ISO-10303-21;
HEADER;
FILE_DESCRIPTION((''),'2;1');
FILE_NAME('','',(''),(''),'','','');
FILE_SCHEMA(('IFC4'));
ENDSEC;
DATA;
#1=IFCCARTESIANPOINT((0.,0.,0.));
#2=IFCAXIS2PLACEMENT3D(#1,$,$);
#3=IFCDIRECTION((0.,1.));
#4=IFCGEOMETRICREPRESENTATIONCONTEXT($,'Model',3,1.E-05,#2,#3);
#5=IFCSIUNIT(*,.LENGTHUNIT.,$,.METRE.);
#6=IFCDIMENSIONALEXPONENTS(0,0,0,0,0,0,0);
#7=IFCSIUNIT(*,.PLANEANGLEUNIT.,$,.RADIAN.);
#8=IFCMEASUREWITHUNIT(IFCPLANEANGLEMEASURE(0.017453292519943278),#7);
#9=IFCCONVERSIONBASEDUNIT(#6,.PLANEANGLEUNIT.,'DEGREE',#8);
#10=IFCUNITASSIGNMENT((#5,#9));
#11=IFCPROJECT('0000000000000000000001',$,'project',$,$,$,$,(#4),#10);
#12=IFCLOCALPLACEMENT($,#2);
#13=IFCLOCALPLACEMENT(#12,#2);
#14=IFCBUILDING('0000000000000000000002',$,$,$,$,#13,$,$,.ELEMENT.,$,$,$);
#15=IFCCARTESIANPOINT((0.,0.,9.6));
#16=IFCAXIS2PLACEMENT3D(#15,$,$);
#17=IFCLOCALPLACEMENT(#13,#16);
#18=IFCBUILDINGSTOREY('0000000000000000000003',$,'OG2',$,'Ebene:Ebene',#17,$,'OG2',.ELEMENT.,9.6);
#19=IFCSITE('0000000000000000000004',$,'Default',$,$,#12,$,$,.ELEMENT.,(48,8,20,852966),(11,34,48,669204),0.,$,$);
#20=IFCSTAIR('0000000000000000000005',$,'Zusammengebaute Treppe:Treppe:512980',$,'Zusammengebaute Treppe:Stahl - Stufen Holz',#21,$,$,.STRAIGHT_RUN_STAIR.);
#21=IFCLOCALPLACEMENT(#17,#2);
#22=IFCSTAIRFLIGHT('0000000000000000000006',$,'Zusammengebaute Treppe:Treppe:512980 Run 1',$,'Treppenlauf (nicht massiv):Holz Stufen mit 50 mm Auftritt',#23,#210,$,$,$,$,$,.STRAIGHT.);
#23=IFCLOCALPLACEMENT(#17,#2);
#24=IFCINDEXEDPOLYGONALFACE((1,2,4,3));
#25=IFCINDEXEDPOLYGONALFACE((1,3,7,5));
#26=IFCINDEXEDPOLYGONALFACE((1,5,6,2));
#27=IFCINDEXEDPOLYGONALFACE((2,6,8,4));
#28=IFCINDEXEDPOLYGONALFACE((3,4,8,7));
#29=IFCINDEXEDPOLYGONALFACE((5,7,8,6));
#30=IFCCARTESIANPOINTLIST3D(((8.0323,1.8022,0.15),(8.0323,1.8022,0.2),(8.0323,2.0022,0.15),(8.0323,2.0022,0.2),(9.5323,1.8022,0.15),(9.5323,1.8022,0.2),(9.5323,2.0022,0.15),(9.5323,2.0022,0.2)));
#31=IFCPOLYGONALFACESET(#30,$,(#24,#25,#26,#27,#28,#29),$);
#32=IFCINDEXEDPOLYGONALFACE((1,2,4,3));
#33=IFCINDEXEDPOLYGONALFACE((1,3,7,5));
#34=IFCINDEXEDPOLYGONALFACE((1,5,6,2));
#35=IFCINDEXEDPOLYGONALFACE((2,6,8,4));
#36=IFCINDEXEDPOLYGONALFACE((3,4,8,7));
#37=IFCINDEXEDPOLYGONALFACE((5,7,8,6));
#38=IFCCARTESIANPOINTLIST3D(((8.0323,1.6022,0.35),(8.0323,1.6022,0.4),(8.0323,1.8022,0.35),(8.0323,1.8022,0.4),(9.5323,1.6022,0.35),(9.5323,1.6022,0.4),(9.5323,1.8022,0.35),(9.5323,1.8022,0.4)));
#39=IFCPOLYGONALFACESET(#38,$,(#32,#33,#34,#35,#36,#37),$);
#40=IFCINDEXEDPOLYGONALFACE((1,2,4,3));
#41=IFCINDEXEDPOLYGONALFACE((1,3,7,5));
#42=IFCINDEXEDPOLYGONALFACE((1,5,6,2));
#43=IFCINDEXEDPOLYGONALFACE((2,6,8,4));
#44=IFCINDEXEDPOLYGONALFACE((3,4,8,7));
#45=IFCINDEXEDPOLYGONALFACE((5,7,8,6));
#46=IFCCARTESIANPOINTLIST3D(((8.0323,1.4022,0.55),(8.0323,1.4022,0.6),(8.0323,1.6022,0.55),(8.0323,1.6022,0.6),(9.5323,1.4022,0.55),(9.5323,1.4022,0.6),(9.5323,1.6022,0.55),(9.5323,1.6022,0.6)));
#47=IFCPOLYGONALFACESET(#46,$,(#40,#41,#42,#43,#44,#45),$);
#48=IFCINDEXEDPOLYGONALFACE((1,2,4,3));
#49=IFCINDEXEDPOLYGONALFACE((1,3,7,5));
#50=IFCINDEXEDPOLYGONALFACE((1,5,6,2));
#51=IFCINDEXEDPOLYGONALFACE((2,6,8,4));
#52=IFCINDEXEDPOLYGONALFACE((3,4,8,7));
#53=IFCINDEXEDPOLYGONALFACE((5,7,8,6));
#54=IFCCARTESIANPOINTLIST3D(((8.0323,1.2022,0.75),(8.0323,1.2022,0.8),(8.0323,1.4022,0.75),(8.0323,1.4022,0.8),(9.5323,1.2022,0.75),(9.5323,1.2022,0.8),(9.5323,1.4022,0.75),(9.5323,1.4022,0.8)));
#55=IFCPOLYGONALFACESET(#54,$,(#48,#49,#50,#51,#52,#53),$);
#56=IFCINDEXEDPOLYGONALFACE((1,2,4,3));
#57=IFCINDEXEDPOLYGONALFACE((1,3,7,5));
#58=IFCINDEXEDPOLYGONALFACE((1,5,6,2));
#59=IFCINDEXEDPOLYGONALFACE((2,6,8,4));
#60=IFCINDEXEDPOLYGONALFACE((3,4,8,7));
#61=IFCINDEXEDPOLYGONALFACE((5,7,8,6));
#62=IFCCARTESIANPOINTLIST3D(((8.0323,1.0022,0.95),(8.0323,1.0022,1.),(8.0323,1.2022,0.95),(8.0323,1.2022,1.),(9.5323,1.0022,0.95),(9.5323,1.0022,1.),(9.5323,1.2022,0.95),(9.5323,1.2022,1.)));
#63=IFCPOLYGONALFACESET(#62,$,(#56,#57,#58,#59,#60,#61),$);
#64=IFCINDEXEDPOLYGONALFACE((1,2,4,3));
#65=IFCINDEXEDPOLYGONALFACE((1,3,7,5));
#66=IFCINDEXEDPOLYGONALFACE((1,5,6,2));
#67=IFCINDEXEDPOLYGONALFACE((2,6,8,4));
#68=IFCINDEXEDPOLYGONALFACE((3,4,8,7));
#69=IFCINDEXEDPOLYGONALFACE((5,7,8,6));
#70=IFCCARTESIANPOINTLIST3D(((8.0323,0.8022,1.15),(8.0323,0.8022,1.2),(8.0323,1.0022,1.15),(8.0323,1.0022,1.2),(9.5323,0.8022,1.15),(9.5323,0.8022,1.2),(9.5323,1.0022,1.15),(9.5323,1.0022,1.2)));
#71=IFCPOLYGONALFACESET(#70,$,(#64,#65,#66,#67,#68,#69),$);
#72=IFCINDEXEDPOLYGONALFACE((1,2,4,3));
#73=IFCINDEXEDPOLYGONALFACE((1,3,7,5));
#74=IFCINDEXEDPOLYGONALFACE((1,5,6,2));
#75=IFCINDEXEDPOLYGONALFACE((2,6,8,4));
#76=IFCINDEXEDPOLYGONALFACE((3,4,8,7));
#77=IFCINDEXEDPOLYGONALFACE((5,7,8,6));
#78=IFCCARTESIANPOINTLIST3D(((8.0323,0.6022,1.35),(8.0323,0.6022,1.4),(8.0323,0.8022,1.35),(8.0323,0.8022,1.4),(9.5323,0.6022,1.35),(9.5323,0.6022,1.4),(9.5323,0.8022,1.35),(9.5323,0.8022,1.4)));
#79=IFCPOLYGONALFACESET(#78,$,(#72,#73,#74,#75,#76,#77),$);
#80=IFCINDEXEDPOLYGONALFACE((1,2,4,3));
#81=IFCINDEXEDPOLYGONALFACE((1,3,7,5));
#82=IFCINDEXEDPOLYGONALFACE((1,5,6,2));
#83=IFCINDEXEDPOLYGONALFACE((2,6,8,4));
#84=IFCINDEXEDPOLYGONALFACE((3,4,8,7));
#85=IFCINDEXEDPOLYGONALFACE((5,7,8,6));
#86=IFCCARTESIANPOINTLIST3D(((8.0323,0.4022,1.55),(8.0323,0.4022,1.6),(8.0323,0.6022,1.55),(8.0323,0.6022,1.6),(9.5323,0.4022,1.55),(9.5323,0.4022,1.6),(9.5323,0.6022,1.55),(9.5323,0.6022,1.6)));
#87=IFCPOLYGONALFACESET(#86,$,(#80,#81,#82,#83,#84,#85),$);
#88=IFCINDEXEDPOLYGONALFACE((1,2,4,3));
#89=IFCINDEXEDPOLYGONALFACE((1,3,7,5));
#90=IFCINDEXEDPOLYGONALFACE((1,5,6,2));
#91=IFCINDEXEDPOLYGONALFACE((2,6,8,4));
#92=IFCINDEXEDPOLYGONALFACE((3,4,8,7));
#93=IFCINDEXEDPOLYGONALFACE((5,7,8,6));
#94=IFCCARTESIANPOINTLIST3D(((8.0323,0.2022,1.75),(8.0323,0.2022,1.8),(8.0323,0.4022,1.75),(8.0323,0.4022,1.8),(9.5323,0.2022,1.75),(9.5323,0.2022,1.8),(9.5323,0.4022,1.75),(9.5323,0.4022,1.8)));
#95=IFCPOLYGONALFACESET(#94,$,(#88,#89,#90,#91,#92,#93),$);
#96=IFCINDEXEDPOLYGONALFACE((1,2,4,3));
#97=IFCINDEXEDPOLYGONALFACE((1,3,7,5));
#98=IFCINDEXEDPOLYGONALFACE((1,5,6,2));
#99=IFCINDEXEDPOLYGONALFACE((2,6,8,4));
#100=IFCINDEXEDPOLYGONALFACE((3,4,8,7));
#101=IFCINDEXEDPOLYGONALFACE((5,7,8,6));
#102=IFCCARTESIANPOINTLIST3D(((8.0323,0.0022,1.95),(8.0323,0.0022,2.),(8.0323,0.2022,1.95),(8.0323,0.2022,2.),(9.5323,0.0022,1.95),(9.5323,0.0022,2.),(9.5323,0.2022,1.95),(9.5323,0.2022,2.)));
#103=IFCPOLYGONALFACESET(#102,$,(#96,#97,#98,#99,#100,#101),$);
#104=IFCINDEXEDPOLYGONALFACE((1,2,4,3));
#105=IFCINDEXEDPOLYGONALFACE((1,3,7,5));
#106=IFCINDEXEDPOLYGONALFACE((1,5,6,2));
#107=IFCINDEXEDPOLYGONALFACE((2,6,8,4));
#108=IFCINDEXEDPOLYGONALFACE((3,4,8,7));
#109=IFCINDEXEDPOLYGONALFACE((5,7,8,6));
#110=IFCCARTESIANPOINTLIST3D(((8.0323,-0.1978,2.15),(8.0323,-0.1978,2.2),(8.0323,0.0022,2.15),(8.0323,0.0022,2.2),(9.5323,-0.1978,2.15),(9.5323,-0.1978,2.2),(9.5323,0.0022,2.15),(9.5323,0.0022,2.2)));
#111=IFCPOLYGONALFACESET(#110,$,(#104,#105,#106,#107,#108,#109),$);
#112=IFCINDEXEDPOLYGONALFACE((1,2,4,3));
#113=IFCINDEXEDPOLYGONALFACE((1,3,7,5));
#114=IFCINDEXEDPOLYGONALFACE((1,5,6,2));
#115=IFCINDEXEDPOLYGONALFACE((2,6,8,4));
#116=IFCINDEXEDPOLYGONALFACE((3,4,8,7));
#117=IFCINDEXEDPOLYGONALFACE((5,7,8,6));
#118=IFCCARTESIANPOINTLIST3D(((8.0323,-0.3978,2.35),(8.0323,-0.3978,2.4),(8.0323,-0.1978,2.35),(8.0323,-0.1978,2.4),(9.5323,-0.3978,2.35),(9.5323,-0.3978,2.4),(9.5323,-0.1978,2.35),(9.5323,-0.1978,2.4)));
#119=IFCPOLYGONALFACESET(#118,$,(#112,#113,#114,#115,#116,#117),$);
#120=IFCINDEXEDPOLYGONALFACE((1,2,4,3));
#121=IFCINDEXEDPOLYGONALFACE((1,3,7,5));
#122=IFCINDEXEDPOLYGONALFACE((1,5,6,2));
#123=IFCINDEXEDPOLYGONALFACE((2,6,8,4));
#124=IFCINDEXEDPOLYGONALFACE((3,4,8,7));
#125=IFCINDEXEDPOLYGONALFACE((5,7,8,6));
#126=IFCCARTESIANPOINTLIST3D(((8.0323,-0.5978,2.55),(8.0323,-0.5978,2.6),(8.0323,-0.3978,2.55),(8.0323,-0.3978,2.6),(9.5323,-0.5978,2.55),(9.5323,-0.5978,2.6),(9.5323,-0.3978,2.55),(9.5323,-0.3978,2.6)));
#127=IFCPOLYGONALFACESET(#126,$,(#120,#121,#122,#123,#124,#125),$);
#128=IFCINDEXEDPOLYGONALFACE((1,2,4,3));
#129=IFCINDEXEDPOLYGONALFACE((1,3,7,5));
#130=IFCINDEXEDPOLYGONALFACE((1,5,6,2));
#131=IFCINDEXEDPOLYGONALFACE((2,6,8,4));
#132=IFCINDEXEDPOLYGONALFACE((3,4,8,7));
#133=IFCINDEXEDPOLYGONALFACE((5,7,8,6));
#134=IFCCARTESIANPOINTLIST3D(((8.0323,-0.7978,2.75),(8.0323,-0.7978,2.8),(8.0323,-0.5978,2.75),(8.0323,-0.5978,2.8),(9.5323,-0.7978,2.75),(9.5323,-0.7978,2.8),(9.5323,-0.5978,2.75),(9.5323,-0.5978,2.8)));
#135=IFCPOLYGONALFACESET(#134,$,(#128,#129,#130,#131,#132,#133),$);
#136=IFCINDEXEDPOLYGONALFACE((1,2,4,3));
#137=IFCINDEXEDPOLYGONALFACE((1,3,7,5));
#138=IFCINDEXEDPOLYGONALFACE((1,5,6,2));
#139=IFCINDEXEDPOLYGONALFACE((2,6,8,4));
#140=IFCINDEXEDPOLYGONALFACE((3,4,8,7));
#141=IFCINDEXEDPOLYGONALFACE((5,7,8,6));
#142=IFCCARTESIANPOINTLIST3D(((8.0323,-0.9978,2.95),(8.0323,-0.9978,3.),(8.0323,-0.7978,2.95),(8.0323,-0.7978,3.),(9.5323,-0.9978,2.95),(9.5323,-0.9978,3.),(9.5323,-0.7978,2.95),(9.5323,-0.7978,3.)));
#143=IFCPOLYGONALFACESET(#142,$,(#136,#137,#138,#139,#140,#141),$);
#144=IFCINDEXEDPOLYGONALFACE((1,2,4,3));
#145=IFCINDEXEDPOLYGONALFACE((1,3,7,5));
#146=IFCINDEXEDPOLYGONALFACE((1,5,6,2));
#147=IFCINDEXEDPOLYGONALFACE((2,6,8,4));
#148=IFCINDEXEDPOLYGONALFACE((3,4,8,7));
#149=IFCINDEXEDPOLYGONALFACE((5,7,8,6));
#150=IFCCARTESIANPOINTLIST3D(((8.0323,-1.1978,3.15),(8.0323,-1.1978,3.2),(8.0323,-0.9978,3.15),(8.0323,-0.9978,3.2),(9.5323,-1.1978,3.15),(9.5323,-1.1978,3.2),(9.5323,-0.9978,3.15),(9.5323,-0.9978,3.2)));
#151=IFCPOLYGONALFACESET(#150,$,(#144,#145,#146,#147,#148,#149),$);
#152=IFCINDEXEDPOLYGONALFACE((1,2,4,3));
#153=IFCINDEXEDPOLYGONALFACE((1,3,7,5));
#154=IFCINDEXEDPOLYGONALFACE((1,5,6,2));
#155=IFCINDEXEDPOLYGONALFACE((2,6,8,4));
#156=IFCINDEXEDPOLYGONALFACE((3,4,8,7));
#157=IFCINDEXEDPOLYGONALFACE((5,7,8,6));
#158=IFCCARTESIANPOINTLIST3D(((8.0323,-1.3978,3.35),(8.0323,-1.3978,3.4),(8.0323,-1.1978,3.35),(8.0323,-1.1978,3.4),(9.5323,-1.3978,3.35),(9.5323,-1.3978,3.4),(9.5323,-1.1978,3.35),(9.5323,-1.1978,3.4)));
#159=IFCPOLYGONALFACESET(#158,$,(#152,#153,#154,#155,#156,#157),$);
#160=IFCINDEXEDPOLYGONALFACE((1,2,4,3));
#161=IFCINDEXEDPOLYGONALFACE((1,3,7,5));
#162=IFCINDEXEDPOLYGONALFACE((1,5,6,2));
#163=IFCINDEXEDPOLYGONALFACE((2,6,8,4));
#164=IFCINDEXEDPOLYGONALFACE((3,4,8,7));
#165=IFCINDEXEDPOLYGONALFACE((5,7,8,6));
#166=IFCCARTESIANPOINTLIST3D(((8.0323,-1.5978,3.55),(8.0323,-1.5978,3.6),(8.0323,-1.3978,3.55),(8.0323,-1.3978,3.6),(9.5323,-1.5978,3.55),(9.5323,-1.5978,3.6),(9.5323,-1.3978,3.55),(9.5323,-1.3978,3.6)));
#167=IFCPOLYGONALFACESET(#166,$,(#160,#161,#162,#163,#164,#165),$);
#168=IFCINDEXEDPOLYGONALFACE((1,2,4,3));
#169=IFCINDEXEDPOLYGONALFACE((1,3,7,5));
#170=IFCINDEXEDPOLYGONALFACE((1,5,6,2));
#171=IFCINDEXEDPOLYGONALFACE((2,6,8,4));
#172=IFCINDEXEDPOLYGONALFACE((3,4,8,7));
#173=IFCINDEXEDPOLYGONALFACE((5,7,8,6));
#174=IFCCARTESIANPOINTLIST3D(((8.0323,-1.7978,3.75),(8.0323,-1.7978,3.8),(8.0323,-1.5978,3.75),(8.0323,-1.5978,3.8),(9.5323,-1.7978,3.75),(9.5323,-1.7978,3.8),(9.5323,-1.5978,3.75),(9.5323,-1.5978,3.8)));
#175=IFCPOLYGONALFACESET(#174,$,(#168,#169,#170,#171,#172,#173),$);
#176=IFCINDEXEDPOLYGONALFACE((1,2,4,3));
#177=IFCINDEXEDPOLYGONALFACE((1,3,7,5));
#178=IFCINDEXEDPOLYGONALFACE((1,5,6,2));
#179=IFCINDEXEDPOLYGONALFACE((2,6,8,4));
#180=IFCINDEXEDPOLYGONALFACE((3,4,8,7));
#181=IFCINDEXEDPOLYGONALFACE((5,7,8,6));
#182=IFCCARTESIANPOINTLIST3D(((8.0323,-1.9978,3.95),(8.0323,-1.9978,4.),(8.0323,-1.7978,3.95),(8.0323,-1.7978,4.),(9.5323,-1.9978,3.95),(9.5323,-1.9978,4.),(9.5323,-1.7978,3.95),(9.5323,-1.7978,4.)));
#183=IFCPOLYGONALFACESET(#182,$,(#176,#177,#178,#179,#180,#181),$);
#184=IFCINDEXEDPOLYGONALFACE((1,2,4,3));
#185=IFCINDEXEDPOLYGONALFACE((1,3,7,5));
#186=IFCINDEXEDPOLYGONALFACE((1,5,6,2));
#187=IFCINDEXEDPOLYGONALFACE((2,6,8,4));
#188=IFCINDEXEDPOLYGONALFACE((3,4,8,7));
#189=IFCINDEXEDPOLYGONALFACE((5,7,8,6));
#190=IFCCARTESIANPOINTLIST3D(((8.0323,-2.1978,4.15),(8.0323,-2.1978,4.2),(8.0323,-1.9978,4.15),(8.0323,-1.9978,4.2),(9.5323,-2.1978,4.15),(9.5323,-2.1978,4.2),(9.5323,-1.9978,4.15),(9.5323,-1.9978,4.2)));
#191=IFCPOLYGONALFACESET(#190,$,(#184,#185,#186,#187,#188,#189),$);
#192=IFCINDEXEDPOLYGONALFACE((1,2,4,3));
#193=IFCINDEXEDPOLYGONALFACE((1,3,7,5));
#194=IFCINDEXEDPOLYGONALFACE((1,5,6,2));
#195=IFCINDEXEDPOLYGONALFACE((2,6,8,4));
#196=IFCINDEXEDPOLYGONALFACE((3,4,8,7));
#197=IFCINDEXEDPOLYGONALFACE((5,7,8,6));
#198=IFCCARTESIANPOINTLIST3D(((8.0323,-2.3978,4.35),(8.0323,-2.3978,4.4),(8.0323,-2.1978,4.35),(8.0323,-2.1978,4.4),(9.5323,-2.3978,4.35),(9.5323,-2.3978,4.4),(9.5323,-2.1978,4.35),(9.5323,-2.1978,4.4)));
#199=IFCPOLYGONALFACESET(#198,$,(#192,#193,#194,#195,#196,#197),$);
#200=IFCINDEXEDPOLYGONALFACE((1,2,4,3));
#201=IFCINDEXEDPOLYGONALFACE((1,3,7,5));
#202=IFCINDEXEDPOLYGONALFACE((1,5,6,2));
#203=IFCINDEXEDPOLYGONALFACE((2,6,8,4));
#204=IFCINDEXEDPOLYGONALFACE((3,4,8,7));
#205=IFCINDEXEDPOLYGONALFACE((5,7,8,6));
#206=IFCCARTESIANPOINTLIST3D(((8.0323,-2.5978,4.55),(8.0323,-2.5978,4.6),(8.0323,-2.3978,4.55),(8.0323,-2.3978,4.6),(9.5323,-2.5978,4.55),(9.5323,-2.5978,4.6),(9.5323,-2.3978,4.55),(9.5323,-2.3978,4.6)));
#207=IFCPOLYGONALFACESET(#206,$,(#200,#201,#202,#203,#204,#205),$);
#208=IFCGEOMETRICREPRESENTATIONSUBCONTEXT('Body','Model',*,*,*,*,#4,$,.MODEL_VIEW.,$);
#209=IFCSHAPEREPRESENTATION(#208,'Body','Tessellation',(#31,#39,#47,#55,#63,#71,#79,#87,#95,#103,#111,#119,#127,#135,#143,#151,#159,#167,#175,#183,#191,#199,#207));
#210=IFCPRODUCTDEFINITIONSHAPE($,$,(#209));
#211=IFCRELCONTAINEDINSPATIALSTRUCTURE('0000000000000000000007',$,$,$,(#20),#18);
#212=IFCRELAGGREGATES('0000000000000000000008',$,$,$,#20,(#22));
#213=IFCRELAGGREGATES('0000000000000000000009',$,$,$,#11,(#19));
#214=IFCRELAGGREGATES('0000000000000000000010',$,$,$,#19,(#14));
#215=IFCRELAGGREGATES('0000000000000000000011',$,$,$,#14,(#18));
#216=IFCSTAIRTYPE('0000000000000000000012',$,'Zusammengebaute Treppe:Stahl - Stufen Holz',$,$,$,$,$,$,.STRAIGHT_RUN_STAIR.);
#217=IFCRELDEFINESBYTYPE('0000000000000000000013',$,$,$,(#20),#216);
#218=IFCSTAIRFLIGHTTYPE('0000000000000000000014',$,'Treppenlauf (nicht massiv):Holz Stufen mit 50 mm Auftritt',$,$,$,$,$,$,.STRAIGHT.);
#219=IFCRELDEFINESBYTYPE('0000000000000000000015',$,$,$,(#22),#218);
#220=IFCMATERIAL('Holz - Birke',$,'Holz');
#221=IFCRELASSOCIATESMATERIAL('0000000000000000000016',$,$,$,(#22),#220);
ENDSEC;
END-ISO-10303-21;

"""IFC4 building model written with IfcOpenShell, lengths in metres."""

from ifc_helpers import new_model, entity, si_unit, converted_unit, direction, frame, origin, place, context, subcontext, project, spatial, indexed_curve, outline, extrude, material, type_object, element, aggregate, save


model = new_model("IFC4")

# Units and contexts
model_context = context("Model", 3, precision=1e-05, world=origin(), true_north=direction((0.0, 1.0)))
body_context = subcontext(model_context, "Body", "Model", "MODEL_VIEW")
ifc_project = project(units=[si_unit("LENGTHUNIT", "METRE"), converted_unit("PLANEANGLEUNIT", "DEGREE", entity("IfcPlaneAngleMeasure", 0.017453292519943278), si_unit("PLANEANGLEUNIT", "RADIAN"), dimensions=[0, 0, 0, 0, 0, 0, 0])], contexts=[model_context])

# Site, building, storey
site_placement = place(None, origin())
site = spatial("IfcSite", under=ifc_project, at=site_placement, Name="Default", CompositionType="ELEMENT", RefLatitude=(48, 8, 20, 852966), RefLongitude=(11, 34, 48, 669204), RefElevation=0.0)
building_placement = place(site_placement, origin())
building = spatial("IfcBuilding", under=site, at=building_placement, CompositionType="ELEMENT")
storey_placement = place(building_placement, frame((0.0, 0.0, 9.6)))
storey = spatial("IfcBuildingStorey", under=building, at=storey_placement, Name="OG2", ObjectType="Ebene:Ebene", LongName="OG2", CompositionType="ELEMENT", Elevation=9.6)

# Stair
stair_type_1 = type_object("IfcStairType", Name="Zusammengebaute Treppe:Stahl - Stufen Holz", PredefinedType="STRAIGHT_RUN_STAIR")
stair_1_placement = place(storey_placement, origin())
stair_1 = element("IfcStair", 1, at=stair_1_placement, inside=storey, type_object=stair_type_1, Name="Zusammengebaute Treppe:Treppe:512980", ObjectType="Zusammengebaute Treppe:Stahl - Stufen Holz", PredefinedType="STRAIGHT_RUN_STAIR")

# Stair flight
ifc_material_1 = material(Name="Holz - Birke", Category="Holz")
stair_flight_type_1 = type_object("IfcStairFlightType", Name="Treppenlauf (nicht massiv):Holz Stufen mit 50 mm Auftritt", PredefinedType="STRAIGHT")
stair_flight_1_placement = place(stair_1_placement, origin())
stair_flight_1 = element("IfcStairFlight", 2, at=stair_flight_1_placement, type_object=stair_flight_type_1, material=ifc_material_1, Name="Zusammengebaute Treppe:Treppe:512980 Run 1", ObjectType="Treppenlauf (nicht massiv):Holz Stufen mit 50 mm Auftritt", PredefinedType="STRAIGHT", context=body_context, shape_type="SweptSolid", body=[
    extrude(outline(indexed_curve([(-0.1, -0.75), (0.1, -0.75), (0.1, 0.75), (-0.1, 0.75), (-0.1, -0.75)], self_intersect=False)), frame((8.7823, 1.9022, 0.15), z_axis=(0.0, 0.0, 1.0), x_axis=(0.0, 1.0, 0.0)), (0.0, 0.0, 1.0), 0.05),
    extrude(outline(indexed_curve([(-0.1, -0.75), (0.1, -0.75), (0.1, 0.75), (-0.1, 0.75), (-0.1, -0.75)], self_intersect=False)), frame((8.7823, 1.7022, 0.35), z_axis=(0.0, 0.0, 1.0), x_axis=(0.0, 1.0, 0.0)), (0.0, 0.0, 1.0), 0.05),
    extrude(outline(indexed_curve([(-0.1, -0.75), (0.1, -0.75), (0.1, 0.75), (-0.1, 0.75), (-0.1, -0.75)], self_intersect=False)), frame((8.7823, 1.5022, 0.55), z_axis=(0.0, 0.0, 1.0), x_axis=(0.0, 1.0, 0.0)), (0.0, 0.0, 1.0), 0.05),
    extrude(outline(indexed_curve([(-0.1, -0.75), (0.1, -0.75), (0.1, 0.75), (-0.1, 0.75), (-0.1, -0.75)], self_intersect=False)), frame((8.7823, 1.3022, 0.75), z_axis=(0.0, 0.0, 1.0), x_axis=(0.0, 1.0, 0.0)), (0.0, 0.0, 1.0), 0.05),
    extrude(outline(indexed_curve([(-0.1, -0.75), (0.1, -0.75), (0.1, 0.75), (-0.1, 0.75), (-0.1, -0.75)], self_intersect=False)), frame((8.7823, 1.1022, 0.95), z_axis=(0.0, 0.0, 1.0), x_axis=(0.0, 1.0, 0.0)), (0.0, 0.0, 1.0), 0.05),
    extrude(outline(indexed_curve([(-0.1, -0.75), (0.1, -0.75), (0.1, 0.75), (-0.1, 0.75), (-0.1, -0.75)], self_intersect=False)), frame((8.7823, 0.9022, 1.15), z_axis=(0.0, 0.0, 1.0), x_axis=(0.0, 1.0, 0.0)), (0.0, 0.0, 1.0), 0.05),
    extrude(outline(indexed_curve([(-0.1, -0.75), (0.1, -0.75), (0.1, 0.75), (-0.1, 0.75), (-0.1, -0.75)], self_intersect=False)), frame((8.7823, 0.7022, 1.35), z_axis=(0.0, 0.0, 1.0), x_axis=(0.0, 1.0, 0.0)), (0.0, 0.0, 1.0), 0.05),
    extrude(outline(indexed_curve([(-0.1, -0.75), (0.1, -0.75), (0.1, 0.75), (-0.1, 0.75), (-0.1, -0.75)], self_intersect=False)), frame((8.7823, 0.5022, 1.55), z_axis=(0.0, 0.0, 1.0), x_axis=(0.0, 1.0, 0.0)), (0.0, 0.0, 1.0), 0.05),
    extrude(outline(indexed_curve([(-0.1, -0.75), (0.1, -0.75), (0.1, 0.75), (-0.1, 0.75), (-0.1, -0.75)], self_intersect=False)), frame((8.7823, 0.3022, 1.75), z_axis=(0.0, 0.0, 1.0), x_axis=(0.0, 1.0, 0.0)), (0.0, 0.0, 1.0), 0.05),
    extrude(outline(indexed_curve([(-0.1, -0.75), (0.1, -0.75), (0.1, 0.75), (-0.1, 0.75), (-0.1, -0.75)], self_intersect=False)), frame((8.7823, 0.1022, 1.95), z_axis=(0.0, 0.0, 1.0), x_axis=(0.0, 1.0, 0.0)), (0.0, 0.0, 1.0), 0.05),
    extrude(outline(indexed_curve([(-0.1, -0.75), (0.1, -0.75), (0.1, 0.75), (-0.1, 0.75), (-0.1, -0.75)], self_intersect=False)), frame((8.7823, -0.0978, 2.15), z_axis=(0.0, 0.0, 1.0), x_axis=(0.0, 1.0, 0.0)), (0.0, 0.0, 1.0), 0.05),
    extrude(outline(indexed_curve([(-0.1, -0.75), (0.1, -0.75), (0.1, 0.75), (-0.1, 0.75), (-0.1, -0.75)], self_intersect=False)), frame((8.7823, -0.2978, 2.35), z_axis=(0.0, 0.0, 1.0), x_axis=(0.0, 1.0, 0.0)), (0.0, 0.0, 1.0), 0.05),
    extrude(outline(indexed_curve([(-0.1, -0.75), (0.1, -0.75), (0.1, 0.75), (-0.1, 0.75), (-0.1, -0.75)], self_intersect=False)), frame((8.7823, -0.4978, 2.55), z_axis=(0.0, 0.0, 1.0), x_axis=(0.0, 1.0, 0.0)), (0.0, 0.0, 1.0), 0.05),
    extrude(outline(indexed_curve([(-0.1, -0.75), (0.1, -0.75), (0.1, 0.75), (-0.1, 0.75), (-0.1, -0.75)], self_intersect=False)), frame((8.7823, -0.6978, 2.75), z_axis=(0.0, 0.0, 1.0), x_axis=(0.0, 1.0, 0.0)), (0.0, 0.0, 1.0), 0.05),
    extrude(outline(indexed_curve([(-0.1, -0.75), (0.1, -0.75), (0.1, 0.75), (-0.1, 0.75), (-0.1, -0.75)], self_intersect=False)), frame((8.7823, -0.8978, 2.95), z_axis=(0.0, 0.0, 1.0), x_axis=(0.0, 1.0, 0.0)), (0.0, 0.0, 1.0), 0.05),
    extrude(outline(indexed_curve([(-0.1, -0.75), (0.1, -0.75), (0.1, 0.75), (-0.1, 0.75), (-0.1, -0.75)], self_intersect=False)), frame((8.7823, -1.0978, 3.15), z_axis=(0.0, 0.0, 1.0), x_axis=(0.0, 1.0, 0.0)), (0.0, 0.0, 1.0), 0.05),
    extrude(outline(indexed_curve([(-0.1, -0.75), (0.1, -0.75), (0.1, 0.75), (-0.1, 0.75), (-0.1, -0.75)], self_intersect=False)), frame((8.7823, -1.2978, 3.35), z_axis=(0.0, 0.0, 1.0), x_axis=(0.0, 1.0, 0.0)), (0.0, 0.0, 1.0), 0.05),
    extrude(outline(indexed_curve([(-0.1, -0.75), (0.1, -0.75), (0.1, 0.75), (-0.1, 0.75), (-0.1, -0.75)], self_intersect=False)), frame((8.7823, -1.4978, 3.55), z_axis=(0.0, 0.0, 1.0), x_axis=(0.0, 1.0, 0.0)), (0.0, 0.0, 1.0), 0.05),
    extrude(outline(indexed_curve([(-0.1, -0.75), (0.1, -0.75), (0.1, 0.75), (-0.1, 0.75), (-0.1, -0.75)], self_intersect=False)), frame((8.7823, -1.6978, 3.75), z_axis=(0.0, 0.0, 1.0), x_axis=(0.0, 1.0, 0.0)), (0.0, 0.0, 1.0), 0.05),
    extrude(outline(indexed_curve([(-0.1, -0.75), (0.1, -0.75), (0.1, 0.75), (-0.1, 0.75), (-0.1, -0.75)], self_intersect=False)), frame((8.7823, -1.8978, 3.95), z_axis=(0.0, 0.0, 1.0), x_axis=(0.0, 1.0, 0.0)), (0.0, 0.0, 1.0), 0.05),
    extrude(outline(indexed_curve([(-0.1, -0.75), (0.1, -0.75), (0.1, 0.75), (-0.1, 0.75), (-0.1, -0.75)], self_intersect=False)), frame((8.7823, -2.0978, 4.15), z_axis=(0.0, 0.0, 1.0), x_axis=(0.0, 1.0, 0.0)), (0.0, 0.0, 1.0), 0.05),
    extrude(outline(indexed_curve([(-0.1, -0.75), (0.1, -0.75), (0.1, 0.75), (-0.1, 0.75), (-0.1, -0.75)], self_intersect=False)), frame((8.7823, -2.2978, 4.35), z_axis=(0.0, 0.0, 1.0), x_axis=(0.0, 1.0, 0.0)), (0.0, 0.0, 1.0), 0.05),
    extrude(outline(indexed_curve([(-0.1, -0.75), (0.1, -0.75), (0.1, 0.75), (-0.1, 0.75), (-0.1, -0.75)], self_intersect=False)), frame((8.7823, -2.4978, 4.55), z_axis=(0.0, 0.0, 1.0), x_axis=(0.0, 1.0, 0.0)), (0.0, 0.0, 1.0), 0.05),
])
aggregate(stair_1, [stair_flight_1])

save(model, "model.ifc")
